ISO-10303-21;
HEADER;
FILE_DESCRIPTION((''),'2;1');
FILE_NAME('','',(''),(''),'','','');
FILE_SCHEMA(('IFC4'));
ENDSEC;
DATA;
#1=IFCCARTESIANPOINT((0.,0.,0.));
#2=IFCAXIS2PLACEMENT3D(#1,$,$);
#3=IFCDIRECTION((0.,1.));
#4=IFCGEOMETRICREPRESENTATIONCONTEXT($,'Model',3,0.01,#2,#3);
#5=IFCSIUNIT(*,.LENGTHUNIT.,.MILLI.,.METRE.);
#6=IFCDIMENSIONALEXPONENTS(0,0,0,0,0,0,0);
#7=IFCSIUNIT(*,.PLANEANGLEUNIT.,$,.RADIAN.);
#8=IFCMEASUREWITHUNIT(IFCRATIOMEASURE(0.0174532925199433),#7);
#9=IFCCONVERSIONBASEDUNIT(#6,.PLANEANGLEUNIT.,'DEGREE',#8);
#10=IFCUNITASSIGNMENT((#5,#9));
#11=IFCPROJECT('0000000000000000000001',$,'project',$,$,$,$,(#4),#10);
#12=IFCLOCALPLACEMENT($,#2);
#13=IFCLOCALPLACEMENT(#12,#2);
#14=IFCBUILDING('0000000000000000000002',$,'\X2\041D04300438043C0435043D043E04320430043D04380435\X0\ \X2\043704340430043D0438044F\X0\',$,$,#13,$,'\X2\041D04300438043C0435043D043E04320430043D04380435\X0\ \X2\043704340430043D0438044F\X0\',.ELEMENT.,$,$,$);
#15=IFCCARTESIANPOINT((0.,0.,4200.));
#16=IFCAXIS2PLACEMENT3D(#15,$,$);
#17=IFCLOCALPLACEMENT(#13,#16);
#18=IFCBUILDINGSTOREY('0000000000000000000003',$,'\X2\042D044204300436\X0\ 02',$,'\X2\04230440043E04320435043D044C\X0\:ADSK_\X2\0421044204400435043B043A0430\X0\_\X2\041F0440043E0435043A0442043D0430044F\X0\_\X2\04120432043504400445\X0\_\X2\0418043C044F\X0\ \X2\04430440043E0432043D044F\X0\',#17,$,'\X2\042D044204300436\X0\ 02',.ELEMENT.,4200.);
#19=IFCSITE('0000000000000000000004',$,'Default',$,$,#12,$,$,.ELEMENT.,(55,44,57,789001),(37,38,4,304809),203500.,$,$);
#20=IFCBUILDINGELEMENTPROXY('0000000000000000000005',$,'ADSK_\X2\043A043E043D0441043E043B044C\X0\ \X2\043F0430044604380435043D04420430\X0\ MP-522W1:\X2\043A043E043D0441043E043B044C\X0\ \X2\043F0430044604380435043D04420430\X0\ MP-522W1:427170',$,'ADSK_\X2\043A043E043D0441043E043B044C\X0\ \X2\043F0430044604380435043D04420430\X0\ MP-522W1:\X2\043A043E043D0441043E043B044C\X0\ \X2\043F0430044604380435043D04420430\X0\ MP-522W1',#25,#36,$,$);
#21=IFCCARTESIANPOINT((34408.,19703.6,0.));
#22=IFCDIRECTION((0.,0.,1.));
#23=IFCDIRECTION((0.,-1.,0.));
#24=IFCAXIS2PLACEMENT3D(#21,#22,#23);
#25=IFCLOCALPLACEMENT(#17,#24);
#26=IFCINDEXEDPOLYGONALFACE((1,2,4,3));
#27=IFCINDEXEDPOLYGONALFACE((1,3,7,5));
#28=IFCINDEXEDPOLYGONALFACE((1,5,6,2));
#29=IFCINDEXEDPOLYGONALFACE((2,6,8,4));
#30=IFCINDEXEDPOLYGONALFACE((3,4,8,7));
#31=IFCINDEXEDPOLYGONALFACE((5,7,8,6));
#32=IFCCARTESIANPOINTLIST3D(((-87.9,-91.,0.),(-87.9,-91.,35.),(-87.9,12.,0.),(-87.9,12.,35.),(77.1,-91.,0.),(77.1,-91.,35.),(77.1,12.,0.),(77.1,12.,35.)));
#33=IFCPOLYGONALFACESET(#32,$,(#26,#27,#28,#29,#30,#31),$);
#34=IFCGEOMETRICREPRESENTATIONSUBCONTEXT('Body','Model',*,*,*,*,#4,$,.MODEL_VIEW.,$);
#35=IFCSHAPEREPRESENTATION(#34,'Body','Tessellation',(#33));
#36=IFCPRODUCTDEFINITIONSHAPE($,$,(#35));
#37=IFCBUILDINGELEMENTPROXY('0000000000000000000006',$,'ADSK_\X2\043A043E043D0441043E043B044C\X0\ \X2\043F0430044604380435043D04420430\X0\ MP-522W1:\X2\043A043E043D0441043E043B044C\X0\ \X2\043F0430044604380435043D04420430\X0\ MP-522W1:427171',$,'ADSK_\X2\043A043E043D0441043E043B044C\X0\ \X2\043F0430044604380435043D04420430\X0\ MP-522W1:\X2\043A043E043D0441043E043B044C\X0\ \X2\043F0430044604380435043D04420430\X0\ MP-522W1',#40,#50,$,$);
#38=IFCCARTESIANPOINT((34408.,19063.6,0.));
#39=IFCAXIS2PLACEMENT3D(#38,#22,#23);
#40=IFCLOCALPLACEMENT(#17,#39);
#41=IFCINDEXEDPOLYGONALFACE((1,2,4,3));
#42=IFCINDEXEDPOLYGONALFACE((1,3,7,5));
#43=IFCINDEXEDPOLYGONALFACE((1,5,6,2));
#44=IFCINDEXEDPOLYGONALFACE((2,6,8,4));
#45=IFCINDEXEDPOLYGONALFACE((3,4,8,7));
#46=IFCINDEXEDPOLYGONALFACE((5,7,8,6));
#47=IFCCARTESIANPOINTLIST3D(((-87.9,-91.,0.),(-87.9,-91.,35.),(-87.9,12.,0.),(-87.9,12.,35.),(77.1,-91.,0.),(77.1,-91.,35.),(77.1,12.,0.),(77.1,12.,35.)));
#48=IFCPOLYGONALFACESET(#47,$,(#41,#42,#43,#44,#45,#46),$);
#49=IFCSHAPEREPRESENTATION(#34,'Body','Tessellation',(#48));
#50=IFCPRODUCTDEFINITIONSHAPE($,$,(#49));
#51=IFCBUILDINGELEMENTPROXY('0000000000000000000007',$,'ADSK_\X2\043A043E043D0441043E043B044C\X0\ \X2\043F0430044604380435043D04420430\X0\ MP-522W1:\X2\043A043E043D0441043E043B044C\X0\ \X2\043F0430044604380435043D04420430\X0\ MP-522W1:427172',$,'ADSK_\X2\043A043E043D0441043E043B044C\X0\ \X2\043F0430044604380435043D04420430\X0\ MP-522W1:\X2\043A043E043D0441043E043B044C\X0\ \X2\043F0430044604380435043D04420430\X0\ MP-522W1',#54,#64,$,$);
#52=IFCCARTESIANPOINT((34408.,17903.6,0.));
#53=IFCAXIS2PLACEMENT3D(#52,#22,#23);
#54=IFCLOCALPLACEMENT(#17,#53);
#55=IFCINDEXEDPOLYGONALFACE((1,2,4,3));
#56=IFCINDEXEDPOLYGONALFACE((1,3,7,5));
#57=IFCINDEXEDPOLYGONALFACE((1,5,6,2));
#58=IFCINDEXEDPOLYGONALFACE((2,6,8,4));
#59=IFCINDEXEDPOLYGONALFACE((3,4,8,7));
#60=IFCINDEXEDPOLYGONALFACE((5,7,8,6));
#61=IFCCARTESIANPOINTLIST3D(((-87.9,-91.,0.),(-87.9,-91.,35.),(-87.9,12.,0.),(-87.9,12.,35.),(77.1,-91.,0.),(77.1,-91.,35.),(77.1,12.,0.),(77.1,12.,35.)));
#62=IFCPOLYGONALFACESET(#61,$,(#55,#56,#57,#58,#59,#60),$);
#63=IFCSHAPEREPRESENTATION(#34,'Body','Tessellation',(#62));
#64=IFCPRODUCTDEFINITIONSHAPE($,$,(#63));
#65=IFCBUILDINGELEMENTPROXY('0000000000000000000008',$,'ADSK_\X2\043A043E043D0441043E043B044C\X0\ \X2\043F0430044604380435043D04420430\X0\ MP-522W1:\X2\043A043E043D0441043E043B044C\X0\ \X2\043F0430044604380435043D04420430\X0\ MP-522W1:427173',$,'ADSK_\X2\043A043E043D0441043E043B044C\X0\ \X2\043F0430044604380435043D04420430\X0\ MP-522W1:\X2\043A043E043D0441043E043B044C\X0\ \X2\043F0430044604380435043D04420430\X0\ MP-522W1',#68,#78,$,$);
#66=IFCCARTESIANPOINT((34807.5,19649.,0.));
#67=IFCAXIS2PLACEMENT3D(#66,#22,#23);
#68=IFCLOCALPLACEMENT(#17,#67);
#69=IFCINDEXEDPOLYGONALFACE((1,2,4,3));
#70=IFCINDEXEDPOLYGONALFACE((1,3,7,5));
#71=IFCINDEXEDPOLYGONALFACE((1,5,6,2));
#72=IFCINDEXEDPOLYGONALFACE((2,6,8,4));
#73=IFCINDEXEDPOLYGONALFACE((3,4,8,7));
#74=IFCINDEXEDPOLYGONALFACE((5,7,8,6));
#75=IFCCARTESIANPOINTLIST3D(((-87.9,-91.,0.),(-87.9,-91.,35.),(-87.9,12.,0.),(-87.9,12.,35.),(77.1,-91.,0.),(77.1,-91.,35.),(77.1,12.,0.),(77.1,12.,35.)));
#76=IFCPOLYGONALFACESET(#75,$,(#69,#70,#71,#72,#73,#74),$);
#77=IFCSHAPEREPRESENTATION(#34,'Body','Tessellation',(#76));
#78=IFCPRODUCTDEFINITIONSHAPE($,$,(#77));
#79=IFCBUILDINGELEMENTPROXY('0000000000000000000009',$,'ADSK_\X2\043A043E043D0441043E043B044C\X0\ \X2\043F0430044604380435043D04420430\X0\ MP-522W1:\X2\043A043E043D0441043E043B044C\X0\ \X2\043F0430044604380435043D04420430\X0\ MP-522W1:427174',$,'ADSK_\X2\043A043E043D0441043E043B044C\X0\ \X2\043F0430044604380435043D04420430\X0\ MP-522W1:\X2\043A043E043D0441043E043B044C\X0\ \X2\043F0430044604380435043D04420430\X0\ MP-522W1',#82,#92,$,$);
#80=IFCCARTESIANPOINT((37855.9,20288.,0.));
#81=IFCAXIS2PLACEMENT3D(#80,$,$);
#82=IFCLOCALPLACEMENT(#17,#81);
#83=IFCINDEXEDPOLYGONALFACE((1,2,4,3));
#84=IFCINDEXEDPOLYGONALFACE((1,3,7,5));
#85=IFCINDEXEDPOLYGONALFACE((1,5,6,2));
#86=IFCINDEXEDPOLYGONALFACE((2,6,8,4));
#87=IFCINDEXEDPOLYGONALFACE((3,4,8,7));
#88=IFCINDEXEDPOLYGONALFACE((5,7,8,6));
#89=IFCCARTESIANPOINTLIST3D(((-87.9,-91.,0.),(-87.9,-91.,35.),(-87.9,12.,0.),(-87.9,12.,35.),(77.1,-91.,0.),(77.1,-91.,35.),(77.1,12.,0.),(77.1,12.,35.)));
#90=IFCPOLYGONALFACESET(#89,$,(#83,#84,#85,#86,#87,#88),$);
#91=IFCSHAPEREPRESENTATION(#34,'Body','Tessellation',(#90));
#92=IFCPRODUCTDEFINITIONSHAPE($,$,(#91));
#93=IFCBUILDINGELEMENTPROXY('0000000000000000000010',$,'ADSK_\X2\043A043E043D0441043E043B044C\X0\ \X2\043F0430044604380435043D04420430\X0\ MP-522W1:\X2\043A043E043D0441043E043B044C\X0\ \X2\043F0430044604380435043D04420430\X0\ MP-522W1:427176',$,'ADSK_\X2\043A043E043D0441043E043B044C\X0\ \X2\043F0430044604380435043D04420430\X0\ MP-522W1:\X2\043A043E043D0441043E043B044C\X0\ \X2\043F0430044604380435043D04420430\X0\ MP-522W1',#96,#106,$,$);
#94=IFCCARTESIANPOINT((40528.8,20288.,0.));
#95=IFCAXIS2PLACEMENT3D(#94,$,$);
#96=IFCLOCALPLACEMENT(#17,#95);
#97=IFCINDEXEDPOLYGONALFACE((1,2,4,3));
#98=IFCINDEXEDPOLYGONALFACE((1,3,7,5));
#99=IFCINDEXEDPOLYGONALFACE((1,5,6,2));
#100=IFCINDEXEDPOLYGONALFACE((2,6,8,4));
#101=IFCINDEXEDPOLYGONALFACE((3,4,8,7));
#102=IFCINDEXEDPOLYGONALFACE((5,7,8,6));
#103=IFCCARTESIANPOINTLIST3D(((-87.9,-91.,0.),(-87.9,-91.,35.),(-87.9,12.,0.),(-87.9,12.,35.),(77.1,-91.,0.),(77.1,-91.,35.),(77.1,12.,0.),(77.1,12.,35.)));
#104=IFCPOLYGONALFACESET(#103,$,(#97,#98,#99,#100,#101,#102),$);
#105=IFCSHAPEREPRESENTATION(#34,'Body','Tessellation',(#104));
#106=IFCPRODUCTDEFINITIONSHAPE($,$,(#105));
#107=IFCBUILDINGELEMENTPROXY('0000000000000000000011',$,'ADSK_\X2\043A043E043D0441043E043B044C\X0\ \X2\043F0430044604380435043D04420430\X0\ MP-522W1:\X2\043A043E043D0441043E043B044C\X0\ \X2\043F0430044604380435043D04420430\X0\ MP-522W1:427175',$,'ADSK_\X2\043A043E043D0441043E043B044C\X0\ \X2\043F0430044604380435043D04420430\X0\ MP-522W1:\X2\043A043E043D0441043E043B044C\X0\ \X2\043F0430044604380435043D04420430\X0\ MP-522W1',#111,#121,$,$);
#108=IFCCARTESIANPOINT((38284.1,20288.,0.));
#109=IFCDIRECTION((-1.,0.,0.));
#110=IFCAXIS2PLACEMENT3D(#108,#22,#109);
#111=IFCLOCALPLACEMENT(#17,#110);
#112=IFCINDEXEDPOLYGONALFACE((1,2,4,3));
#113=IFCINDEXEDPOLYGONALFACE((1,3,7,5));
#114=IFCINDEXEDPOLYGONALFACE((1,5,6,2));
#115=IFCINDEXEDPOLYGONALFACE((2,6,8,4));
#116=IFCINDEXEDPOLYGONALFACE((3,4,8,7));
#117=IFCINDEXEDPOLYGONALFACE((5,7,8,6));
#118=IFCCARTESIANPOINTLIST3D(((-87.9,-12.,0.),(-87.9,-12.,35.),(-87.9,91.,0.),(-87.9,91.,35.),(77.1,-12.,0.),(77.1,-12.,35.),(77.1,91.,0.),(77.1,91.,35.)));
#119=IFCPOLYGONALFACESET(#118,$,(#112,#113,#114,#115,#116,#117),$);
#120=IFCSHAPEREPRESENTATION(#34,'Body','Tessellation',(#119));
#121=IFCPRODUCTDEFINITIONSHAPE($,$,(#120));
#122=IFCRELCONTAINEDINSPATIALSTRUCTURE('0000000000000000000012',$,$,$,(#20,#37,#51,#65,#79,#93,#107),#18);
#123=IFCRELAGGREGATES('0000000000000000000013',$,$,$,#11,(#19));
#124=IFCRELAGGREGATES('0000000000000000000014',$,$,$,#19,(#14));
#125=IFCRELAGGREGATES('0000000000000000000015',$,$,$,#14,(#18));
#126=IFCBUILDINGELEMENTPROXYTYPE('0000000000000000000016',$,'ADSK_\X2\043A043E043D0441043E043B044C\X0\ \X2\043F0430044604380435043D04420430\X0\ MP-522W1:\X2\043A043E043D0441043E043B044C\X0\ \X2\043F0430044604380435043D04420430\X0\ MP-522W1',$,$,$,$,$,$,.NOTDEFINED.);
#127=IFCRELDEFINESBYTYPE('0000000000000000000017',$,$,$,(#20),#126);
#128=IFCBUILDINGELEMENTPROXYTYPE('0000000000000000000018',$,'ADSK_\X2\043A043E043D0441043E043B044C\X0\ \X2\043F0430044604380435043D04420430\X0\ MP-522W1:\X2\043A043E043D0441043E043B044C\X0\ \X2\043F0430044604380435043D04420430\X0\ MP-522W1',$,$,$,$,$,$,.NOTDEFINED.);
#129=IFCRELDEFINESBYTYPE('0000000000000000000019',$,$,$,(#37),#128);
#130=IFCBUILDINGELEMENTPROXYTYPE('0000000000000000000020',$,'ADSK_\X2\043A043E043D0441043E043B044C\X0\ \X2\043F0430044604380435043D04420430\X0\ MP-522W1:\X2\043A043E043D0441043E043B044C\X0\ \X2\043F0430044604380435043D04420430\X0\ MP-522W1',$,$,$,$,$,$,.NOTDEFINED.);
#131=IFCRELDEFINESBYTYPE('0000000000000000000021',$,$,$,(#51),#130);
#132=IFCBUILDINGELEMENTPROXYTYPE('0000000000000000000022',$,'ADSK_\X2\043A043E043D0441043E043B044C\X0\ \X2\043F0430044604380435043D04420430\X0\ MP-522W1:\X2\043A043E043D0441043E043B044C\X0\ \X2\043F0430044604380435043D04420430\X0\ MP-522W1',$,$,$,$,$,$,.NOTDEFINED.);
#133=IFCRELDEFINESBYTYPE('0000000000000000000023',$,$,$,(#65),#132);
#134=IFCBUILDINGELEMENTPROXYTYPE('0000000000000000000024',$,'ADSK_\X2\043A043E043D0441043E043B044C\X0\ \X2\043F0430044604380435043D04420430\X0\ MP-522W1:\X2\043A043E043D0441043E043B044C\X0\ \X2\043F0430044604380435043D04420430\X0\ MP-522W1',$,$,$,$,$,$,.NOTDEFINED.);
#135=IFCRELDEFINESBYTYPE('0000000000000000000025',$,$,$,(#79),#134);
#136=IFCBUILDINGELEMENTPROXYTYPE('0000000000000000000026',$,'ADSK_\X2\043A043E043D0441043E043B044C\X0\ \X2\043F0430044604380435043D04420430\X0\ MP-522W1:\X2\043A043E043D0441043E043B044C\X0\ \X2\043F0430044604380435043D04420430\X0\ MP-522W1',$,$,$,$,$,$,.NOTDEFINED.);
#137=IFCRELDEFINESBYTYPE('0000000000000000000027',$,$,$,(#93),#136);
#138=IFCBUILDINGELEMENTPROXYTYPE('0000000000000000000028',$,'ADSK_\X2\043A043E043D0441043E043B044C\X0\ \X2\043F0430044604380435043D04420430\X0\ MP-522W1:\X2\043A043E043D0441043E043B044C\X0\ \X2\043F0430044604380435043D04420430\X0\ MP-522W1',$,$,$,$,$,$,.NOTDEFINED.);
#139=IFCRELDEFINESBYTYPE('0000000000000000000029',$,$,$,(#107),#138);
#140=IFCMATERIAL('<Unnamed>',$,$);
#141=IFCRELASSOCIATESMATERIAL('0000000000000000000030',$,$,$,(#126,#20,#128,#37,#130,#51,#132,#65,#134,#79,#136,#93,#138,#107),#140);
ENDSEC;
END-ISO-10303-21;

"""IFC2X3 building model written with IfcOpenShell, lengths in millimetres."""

from ifc_helpers import new_model, entity, si_unit, converted_unit, direction, frame, origin, origin_2d_with_axis, place, context, subcontext, project, spatial, rectangle, extrude, source, transform, mapped, material, type_object, type_shapes, element, save


model = new_model("IFC2X3")

# Units and contexts
model_context = context("Model", 3, precision=0.01, world=origin(), true_north=direction((0.0, 1.0)))
body_context = subcontext(model_context, "Body", "Model", "MODEL_VIEW")
ifc_project = project(units=[si_unit("LENGTHUNIT", "METRE", prefix="MILLI"), converted_unit("PLANEANGLEUNIT", "DEGREE", entity("IfcRatioMeasure", 0.0174532925199433), si_unit("PLANEANGLEUNIT", "RADIAN"), dimensions=[0, 0, 0, 0, 0, 0, 0])], contexts=[model_context])

# Site, building, storey
site_placement = place(None, origin())
site = spatial("IfcSite", under=ifc_project, at=site_placement, Name="Default", CompositionType="ELEMENT", RefLatitude=(55, 44, 57, 789001), RefLongitude=(37, 38, 4, 304809), RefElevation=203500.0)
building_placement = place(site_placement, origin())
building = spatial("IfcBuilding", under=site, at=building_placement, Name="Наименование здания", LongName="Наименование здания", CompositionType="ELEMENT")
storey_placement = place(building_placement, frame((0.0, 0.0, 4200.0)))
storey = spatial("IfcBuildingStorey", under=building, at=storey_placement, Name="Этаж 02", ObjectType="Уровень:ADSK_Стрелка_Проектная_Вверх_Имя уровня", LongName="Этаж 02", CompositionType="ELEMENT", Elevation=4200.0)

# Building element proxies
ifc_material_1 = material(Name="<Unnamed>")
building_element_proxy_type_1 = type_object("IfcBuildingElementProxyType", Name="ADSK_консоль пациента MP-522W1:консоль пациента MP-522W1", PredefinedType="NOTDEFINED", material=ifc_material_1)
shared_shape_1 = source(origin(), body_context, "Body", "SweptSolid", [
    extrude(rectangle(XDim=165.0, YDim=103.0, at=origin_2d_with_axis()), frame((-5.4, -39.5, 0.0), z_axis=(0.0, 0.0, 1.0), x_axis=(-1.0, 0.0, 0.0)), (0.0, 0.0, 1.0), 35.0),
])
type_shapes(building_element_proxy_type_1, [shared_shape_1])
proxy_1_placement = place(storey_placement, frame((34408.0, 19703.6, 0.0), z_axis=(0.0, 0.0, 1.0), x_axis=(0.0, -1.0, 0.0)))
element("IfcBuildingElementProxy", 1, at=proxy_1_placement, inside=storey, type_object=building_element_proxy_type_1, material=ifc_material_1, Name="ADSK_консоль пациента MP-522W1:консоль пациента MP-522W1:427170", ObjectType="ADSK_консоль пациента MP-522W1:консоль пациента MP-522W1", context=body_context, shape_type="MappedRepresentation", body=[
    mapped(shared_shape_1, transform((0.0, 0.0, 0.0), scale=1.0)),
])
building_element_proxy_type_2 = type_object("IfcBuildingElementProxyType", Name="ADSK_консоль пациента MP-522W1:консоль пациента MP-522W1", PredefinedType="NOTDEFINED", material=ifc_material_1)
type_shapes(building_element_proxy_type_2, [shared_shape_1])
proxy_2_placement = place(storey_placement, frame((34408.0, 19063.6, 0.0), z_axis=(0.0, 0.0, 1.0), x_axis=(0.0, -1.0, 0.0)))
element("IfcBuildingElementProxy", 2, at=proxy_2_placement, inside=storey, type_object=building_element_proxy_type_2, material=ifc_material_1, Name="ADSK_консоль пациента MP-522W1:консоль пациента MP-522W1:427171", ObjectType="ADSK_консоль пациента MP-522W1:консоль пациента MP-522W1", context=body_context, shape_type="MappedRepresentation", body=[
    mapped(shared_shape_1, transform((0.0, 0.0, 0.0), scale=1.0)),
])
building_element_proxy_type_3 = type_object("IfcBuildingElementProxyType", Name="ADSK_консоль пациента MP-522W1:консоль пациента MP-522W1", PredefinedType="NOTDEFINED", material=ifc_material_1)
type_shapes(building_element_proxy_type_3, [shared_shape_1])
proxy_3_placement = place(storey_placement, frame((34408.0, 17903.6, 0.0), z_axis=(0.0, 0.0, 1.0), x_axis=(0.0, -1.0, 0.0)))
element("IfcBuildingElementProxy", 3, at=proxy_3_placement, inside=storey, type_object=building_element_proxy_type_3, material=ifc_material_1, Name="ADSK_консоль пациента MP-522W1:консоль пациента MP-522W1:427172", ObjectType="ADSK_консоль пациента MP-522W1:консоль пациента MP-522W1", context=body_context, shape_type="MappedRepresentation", body=[
    mapped(shared_shape_1, transform((0.0, 0.0, 0.0), scale=1.0)),
])
building_element_proxy_type_4 = type_object("IfcBuildingElementProxyType", Name="ADSK_консоль пациента MP-522W1:консоль пациента MP-522W1", PredefinedType="NOTDEFINED", material=ifc_material_1)
type_shapes(building_element_proxy_type_4, [shared_shape_1])
proxy_4_placement = place(storey_placement, frame((34807.5, 19649.0, 0.0), z_axis=(0.0, 0.0, 1.0), x_axis=(0.0, -1.0, 0.0)))
element("IfcBuildingElementProxy", 4, at=proxy_4_placement, inside=storey, type_object=building_element_proxy_type_4, material=ifc_material_1, Name="ADSK_консоль пациента MP-522W1:консоль пациента MP-522W1:427173", ObjectType="ADSK_консоль пациента MP-522W1:консоль пациента MP-522W1", context=body_context, shape_type="MappedRepresentation", body=[
    mapped(shared_shape_1, transform((0.0, 0.0, 0.0), scale=1.0)),
])
building_element_proxy_type_5 = type_object("IfcBuildingElementProxyType", Name="ADSK_консоль пациента MP-522W1:консоль пациента MP-522W1", PredefinedType="NOTDEFINED", material=ifc_material_1)
type_shapes(building_element_proxy_type_5, [shared_shape_1])
proxy_5_placement = place(storey_placement, frame((37855.9, 20288.0, 0.0)))
element("IfcBuildingElementProxy", 5, at=proxy_5_placement, inside=storey, type_object=building_element_proxy_type_5, material=ifc_material_1, Name="ADSK_консоль пациента MP-522W1:консоль пациента MP-522W1:427174", ObjectType="ADSK_консоль пациента MP-522W1:консоль пациента MP-522W1", context=body_context, shape_type="MappedRepresentation", body=[
    mapped(shared_shape_1, transform((0.0, 0.0, 0.0), scale=1.0)),
])
building_element_proxy_type_6 = type_object("IfcBuildingElementProxyType", Name="ADSK_консоль пациента MP-522W1:консоль пациента MP-522W1", PredefinedType="NOTDEFINED", material=ifc_material_1)
type_shapes(building_element_proxy_type_6, [shared_shape_1])
proxy_6_placement = place(storey_placement, frame((40528.8, 20288.0, 0.0)))
element("IfcBuildingElementProxy", 6, at=proxy_6_placement, inside=storey, type_object=building_element_proxy_type_6, material=ifc_material_1, Name="ADSK_консоль пациента MP-522W1:консоль пациента MP-522W1:427176", ObjectType="ADSK_консоль пациента MP-522W1:консоль пациента MP-522W1", context=body_context, shape_type="MappedRepresentation", body=[
    mapped(shared_shape_1, transform((0.0, 0.0, 0.0), scale=1.0)),
])
building_element_proxy_type_7 = type_object("IfcBuildingElementProxyType", Name="ADSK_консоль пациента MP-522W1:консоль пациента MP-522W1", PredefinedType="NOTDEFINED", material=ifc_material_1)
shared_shape_2 = source(origin(), body_context, "Body", "SweptSolid", [
    extrude(rectangle(XDim=103.0, YDim=165.0, at=origin_2d_with_axis()), frame((-5.4, 39.5, 0.0), z_axis=(0.0, 0.0, 1.0), x_axis=(0.0, 1.0, 0.0)), (0.0, 0.0, 1.0), 35.0),
])
type_shapes(building_element_proxy_type_7, [shared_shape_2])
proxy_7_placement = place(storey_placement, frame((38284.1, 20288.0, 0.0), z_axis=(0.0, 0.0, 1.0), x_axis=(-1.0, 0.0, 0.0)))
element("IfcBuildingElementProxy", 7, at=proxy_7_placement, inside=storey, type_object=building_element_proxy_type_7, material=ifc_material_1, Name="ADSK_консоль пациента MP-522W1:консоль пациента MP-522W1:427175", ObjectType="ADSK_консоль пациента MP-522W1:консоль пациента MP-522W1", context=body_context, shape_type="MappedRepresentation", body=[
    mapped(shared_shape_2, transform((0.0, 0.0, 0.0), scale=1.0)),
])

save(model, "model.ifc")
